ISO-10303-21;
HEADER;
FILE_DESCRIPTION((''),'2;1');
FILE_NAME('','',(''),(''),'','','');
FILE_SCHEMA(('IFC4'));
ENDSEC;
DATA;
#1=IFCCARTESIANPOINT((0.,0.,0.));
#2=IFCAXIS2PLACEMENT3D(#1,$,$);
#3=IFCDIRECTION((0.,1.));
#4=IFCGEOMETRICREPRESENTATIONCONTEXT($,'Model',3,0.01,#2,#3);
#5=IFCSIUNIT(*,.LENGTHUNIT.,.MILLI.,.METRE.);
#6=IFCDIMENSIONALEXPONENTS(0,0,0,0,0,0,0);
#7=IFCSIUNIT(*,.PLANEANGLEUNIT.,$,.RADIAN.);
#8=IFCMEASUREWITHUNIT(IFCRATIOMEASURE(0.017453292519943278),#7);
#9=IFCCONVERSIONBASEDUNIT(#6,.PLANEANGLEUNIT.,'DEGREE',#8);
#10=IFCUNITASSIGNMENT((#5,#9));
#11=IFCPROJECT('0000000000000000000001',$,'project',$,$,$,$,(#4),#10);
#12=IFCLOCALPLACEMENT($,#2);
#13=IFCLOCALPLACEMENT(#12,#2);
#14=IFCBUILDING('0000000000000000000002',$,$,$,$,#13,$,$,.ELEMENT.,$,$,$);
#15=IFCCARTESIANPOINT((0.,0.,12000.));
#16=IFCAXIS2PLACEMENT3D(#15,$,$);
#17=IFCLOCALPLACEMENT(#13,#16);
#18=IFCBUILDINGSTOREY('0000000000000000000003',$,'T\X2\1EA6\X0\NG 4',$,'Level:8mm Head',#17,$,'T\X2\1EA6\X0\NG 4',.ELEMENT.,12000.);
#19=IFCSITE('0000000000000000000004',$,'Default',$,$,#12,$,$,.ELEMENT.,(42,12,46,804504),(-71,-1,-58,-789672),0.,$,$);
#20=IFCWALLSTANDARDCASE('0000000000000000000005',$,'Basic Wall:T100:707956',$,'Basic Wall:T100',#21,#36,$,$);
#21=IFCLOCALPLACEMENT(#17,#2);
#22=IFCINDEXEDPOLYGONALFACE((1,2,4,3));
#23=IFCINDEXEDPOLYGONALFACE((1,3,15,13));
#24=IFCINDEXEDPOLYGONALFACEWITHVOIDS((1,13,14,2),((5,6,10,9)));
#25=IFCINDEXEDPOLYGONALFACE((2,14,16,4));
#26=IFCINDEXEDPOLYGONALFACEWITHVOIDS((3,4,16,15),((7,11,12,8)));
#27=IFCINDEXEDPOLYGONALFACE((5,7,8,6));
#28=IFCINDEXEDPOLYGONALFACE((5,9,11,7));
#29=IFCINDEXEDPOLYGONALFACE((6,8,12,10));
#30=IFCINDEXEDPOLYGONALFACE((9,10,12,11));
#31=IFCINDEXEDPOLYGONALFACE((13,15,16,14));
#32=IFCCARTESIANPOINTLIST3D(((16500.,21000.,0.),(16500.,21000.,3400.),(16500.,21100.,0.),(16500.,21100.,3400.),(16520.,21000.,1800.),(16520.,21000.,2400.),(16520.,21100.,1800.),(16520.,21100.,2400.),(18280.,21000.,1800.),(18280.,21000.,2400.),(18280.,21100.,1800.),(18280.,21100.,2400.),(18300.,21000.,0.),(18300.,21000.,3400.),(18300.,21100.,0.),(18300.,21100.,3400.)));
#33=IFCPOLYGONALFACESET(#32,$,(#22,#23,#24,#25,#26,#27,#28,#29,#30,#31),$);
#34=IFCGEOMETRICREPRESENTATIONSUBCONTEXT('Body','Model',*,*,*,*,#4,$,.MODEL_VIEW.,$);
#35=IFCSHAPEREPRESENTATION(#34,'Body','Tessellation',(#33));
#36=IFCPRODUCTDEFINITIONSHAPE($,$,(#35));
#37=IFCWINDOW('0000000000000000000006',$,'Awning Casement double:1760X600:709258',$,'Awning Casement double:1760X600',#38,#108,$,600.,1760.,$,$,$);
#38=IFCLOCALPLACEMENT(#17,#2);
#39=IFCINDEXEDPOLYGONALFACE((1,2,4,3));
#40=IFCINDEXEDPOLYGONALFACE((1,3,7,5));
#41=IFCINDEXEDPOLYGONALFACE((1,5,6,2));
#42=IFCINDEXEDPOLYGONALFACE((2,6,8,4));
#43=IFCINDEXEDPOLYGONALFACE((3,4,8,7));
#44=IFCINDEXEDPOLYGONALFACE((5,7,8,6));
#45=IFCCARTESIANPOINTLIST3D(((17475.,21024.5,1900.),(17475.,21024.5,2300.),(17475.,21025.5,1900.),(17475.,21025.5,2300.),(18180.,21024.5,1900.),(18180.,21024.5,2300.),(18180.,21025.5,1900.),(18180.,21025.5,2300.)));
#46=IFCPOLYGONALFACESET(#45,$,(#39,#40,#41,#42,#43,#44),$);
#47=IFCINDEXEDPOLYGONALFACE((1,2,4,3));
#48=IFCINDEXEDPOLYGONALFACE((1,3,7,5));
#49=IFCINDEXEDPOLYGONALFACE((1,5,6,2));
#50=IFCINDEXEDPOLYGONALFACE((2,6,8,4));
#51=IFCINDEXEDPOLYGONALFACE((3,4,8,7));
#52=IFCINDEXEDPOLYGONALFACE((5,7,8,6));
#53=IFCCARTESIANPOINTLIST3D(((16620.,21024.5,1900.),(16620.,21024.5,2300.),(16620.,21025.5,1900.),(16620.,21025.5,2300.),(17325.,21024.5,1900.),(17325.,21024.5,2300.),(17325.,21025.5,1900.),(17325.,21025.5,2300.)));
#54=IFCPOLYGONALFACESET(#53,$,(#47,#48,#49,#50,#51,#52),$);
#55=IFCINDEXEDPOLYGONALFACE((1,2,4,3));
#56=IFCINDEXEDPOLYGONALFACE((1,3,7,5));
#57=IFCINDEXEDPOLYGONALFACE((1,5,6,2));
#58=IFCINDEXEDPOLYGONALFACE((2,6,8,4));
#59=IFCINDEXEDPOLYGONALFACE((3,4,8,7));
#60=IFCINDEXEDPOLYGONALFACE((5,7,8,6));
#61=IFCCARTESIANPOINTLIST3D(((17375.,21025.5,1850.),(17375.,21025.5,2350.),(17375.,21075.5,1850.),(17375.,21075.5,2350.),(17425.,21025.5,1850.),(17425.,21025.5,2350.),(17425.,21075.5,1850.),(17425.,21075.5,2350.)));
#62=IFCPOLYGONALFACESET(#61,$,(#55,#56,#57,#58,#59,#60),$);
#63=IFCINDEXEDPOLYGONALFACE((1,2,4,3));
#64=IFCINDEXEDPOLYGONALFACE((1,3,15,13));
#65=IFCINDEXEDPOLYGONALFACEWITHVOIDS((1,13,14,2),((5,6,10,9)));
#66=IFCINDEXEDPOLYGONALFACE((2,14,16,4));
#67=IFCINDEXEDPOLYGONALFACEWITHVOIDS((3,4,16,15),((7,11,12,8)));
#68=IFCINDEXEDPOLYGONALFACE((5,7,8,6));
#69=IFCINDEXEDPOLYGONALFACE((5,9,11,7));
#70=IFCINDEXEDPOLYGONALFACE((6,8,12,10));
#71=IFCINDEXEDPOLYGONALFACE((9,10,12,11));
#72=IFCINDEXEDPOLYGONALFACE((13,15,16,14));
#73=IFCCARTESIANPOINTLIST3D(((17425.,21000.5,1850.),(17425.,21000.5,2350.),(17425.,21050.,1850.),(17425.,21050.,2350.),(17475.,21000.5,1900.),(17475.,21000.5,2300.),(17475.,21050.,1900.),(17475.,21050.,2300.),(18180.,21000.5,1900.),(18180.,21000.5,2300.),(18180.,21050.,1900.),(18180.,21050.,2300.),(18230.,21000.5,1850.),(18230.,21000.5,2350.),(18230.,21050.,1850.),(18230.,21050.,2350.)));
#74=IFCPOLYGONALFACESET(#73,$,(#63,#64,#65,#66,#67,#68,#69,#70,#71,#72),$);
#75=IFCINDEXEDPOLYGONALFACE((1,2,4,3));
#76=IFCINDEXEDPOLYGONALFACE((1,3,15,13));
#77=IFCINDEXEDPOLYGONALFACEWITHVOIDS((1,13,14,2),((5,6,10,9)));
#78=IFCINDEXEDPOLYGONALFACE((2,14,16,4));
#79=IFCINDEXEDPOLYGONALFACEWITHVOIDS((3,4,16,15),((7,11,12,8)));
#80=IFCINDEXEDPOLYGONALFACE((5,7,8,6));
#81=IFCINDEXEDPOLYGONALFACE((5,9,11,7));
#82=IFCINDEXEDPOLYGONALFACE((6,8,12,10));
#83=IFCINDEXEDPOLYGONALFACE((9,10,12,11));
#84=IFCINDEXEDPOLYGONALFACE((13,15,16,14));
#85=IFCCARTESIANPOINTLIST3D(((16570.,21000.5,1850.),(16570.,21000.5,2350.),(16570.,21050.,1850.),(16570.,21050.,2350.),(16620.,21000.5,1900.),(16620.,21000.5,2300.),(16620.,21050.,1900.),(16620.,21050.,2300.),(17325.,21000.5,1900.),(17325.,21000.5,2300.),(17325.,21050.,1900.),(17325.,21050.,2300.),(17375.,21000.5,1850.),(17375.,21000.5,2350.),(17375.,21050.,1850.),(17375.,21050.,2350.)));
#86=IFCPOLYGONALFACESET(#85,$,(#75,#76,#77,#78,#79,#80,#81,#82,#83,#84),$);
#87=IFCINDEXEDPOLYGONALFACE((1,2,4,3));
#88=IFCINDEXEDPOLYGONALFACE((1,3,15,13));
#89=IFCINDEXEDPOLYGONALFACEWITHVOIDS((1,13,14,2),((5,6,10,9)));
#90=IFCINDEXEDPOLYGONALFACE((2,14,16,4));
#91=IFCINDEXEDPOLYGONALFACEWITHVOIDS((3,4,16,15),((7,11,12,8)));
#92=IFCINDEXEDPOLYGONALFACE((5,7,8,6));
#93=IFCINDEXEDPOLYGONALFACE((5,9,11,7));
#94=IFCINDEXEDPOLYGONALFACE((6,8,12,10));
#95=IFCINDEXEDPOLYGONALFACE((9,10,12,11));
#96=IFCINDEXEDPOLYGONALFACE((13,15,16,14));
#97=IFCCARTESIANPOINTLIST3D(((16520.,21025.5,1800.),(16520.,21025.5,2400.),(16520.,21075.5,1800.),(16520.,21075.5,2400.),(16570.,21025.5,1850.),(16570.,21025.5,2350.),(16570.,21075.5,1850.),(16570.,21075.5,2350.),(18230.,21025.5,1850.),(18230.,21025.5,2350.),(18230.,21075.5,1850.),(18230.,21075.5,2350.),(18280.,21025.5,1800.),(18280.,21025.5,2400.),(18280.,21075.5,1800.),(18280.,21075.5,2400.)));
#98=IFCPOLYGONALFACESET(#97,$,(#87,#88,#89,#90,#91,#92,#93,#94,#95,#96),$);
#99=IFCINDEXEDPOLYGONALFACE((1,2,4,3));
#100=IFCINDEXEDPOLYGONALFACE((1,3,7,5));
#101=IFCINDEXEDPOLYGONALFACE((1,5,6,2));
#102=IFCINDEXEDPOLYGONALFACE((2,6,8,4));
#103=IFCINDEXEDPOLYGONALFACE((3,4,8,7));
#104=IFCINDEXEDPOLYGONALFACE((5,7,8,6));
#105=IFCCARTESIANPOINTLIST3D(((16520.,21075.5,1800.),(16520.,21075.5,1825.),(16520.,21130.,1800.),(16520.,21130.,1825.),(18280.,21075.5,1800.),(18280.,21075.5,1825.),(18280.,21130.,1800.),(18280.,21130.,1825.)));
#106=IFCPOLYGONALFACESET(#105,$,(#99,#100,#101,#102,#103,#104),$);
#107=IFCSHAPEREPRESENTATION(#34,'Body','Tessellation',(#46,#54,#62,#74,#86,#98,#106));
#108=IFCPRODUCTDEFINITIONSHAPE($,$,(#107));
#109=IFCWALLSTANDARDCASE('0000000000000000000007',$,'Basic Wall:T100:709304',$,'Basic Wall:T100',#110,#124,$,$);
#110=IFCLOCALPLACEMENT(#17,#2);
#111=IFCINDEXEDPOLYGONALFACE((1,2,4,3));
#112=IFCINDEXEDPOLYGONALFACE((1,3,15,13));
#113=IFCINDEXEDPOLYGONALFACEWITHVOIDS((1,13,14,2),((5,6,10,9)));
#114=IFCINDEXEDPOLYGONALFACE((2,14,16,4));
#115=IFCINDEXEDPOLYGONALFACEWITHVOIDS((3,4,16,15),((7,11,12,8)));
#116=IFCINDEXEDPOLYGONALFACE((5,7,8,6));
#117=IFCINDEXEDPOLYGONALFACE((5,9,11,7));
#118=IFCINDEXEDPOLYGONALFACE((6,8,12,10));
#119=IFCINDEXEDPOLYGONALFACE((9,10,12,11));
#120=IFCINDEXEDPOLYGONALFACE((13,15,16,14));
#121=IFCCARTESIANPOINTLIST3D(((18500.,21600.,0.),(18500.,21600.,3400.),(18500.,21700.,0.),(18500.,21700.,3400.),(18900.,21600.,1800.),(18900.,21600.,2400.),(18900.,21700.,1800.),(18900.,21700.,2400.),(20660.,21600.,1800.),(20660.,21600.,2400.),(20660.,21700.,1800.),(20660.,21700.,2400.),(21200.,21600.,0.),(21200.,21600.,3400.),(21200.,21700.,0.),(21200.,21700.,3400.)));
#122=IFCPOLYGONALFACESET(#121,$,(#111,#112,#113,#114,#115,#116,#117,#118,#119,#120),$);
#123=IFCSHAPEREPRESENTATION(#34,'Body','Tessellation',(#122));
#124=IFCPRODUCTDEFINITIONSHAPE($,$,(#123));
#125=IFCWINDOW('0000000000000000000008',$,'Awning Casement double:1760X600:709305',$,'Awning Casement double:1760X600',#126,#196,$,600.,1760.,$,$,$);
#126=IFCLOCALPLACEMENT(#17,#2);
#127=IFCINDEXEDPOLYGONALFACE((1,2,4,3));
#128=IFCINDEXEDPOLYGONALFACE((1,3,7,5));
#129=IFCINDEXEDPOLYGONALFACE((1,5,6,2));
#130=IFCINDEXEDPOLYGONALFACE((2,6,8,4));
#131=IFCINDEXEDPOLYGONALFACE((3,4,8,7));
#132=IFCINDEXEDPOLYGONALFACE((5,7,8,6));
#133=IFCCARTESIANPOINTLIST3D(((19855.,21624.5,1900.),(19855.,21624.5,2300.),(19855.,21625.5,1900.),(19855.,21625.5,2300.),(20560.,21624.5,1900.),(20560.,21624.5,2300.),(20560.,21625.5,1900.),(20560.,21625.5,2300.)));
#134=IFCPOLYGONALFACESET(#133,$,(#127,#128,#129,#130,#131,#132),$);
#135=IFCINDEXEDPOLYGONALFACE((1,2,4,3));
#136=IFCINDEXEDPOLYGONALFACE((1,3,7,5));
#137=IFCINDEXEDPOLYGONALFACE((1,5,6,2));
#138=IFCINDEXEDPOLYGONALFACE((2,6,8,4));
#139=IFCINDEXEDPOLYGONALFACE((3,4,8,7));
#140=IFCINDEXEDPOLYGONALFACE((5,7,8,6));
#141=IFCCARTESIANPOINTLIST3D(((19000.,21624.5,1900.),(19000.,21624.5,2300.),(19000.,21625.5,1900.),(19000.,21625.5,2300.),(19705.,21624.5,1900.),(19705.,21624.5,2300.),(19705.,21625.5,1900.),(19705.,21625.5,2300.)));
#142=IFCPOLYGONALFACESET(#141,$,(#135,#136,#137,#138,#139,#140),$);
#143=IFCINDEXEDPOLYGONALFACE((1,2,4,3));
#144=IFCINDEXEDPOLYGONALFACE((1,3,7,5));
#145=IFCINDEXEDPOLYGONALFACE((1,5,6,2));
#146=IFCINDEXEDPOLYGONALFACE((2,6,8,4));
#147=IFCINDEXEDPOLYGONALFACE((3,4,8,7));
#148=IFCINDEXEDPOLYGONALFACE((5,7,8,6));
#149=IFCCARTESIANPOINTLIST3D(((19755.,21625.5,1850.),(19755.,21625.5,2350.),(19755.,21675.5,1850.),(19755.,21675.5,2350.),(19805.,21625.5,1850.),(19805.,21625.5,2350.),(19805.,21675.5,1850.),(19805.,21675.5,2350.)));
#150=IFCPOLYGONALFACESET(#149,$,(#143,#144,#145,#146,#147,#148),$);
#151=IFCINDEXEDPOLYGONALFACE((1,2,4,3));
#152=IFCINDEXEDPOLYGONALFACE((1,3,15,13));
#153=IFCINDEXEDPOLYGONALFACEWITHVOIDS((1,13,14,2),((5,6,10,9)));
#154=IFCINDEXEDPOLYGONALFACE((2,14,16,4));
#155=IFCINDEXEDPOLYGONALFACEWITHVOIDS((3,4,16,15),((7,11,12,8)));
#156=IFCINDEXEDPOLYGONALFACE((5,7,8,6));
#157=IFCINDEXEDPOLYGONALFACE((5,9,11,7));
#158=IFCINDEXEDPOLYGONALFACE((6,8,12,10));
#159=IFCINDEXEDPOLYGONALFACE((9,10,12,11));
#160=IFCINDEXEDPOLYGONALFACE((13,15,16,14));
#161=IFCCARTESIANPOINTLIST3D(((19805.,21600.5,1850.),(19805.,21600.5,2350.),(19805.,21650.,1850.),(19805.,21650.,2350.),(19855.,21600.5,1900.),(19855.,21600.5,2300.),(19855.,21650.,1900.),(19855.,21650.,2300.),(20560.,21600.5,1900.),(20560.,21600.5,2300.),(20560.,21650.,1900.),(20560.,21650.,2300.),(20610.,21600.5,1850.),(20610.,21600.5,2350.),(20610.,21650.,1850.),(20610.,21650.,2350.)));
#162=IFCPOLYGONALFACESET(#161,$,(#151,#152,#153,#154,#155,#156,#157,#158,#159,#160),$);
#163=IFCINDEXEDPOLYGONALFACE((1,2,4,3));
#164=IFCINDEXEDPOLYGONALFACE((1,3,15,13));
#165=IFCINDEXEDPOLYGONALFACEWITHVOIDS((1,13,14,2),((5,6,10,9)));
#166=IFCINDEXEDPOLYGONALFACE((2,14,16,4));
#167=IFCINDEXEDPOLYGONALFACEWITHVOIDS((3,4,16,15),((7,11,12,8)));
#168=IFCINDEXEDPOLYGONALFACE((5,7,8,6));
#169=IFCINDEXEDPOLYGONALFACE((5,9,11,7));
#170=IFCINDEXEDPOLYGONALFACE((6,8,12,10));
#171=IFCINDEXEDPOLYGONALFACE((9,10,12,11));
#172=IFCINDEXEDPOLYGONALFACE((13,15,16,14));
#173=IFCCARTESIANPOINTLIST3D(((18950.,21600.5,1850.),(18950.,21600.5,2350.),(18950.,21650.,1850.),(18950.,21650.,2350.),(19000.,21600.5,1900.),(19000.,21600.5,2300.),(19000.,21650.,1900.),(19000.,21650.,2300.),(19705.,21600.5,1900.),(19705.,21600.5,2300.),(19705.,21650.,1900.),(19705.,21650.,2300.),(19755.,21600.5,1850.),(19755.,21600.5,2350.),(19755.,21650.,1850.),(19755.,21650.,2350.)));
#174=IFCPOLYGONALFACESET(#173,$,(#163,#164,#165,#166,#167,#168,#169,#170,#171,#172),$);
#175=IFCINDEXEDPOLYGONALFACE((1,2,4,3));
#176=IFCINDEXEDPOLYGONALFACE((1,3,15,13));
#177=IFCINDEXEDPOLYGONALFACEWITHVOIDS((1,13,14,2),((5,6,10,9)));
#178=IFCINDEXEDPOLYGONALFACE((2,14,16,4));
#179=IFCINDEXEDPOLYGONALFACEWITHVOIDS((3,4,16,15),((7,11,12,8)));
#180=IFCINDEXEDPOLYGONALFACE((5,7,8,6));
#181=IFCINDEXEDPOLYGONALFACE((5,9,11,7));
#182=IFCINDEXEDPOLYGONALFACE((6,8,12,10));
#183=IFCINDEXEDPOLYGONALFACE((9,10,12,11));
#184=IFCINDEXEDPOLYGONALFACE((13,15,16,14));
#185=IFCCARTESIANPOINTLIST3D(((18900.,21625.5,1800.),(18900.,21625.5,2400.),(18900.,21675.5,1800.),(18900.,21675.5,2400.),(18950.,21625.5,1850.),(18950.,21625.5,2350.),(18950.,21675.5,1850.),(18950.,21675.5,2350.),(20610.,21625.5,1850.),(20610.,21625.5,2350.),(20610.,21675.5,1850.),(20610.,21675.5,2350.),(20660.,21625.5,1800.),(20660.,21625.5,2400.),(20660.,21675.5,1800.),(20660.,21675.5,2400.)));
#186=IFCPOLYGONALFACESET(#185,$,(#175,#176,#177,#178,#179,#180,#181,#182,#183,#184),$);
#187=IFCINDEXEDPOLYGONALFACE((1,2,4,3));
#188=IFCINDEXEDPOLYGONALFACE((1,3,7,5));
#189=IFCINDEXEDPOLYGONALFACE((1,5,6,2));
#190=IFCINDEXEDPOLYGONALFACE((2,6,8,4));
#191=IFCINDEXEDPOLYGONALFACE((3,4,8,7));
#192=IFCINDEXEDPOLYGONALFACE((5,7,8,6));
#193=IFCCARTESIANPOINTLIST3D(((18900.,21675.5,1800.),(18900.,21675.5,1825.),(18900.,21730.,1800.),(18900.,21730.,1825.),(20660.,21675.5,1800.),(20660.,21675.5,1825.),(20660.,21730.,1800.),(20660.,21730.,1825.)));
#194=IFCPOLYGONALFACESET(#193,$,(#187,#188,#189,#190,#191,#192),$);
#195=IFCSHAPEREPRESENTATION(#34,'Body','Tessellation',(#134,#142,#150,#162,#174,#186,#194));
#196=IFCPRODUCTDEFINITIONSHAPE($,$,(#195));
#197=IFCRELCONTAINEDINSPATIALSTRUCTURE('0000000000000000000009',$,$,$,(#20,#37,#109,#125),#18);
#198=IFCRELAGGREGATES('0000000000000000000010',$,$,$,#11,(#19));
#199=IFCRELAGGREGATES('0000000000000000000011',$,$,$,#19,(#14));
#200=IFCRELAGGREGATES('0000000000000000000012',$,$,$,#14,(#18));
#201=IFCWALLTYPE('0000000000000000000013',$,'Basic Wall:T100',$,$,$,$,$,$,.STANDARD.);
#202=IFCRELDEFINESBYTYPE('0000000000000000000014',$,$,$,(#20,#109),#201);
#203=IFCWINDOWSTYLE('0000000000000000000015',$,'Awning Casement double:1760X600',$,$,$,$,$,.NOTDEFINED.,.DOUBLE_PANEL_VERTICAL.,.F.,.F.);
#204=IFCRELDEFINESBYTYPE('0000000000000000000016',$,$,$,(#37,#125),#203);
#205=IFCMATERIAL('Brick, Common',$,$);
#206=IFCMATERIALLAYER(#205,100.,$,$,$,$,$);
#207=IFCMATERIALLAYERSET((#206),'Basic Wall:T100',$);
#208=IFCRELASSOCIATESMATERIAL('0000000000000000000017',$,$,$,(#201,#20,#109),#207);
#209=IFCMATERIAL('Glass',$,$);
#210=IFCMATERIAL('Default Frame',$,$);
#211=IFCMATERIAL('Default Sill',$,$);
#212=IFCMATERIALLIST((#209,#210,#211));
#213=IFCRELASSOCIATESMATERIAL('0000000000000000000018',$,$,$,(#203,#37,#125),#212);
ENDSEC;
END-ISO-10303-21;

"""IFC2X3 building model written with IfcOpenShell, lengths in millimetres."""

from ifc_helpers import new_model, entity, si_unit, converted_unit, direction, frame, frame_2d, origin, origin_2d_with_axis, place, context, subcontext, project, spatial, polyline, rectangle, outline, extrude, source, transform, mapped, material, material_list, layer, layer_set, layer_usage, type_object, type_shapes, element, fill, save


model = new_model("IFC2X3")

# Units and contexts
model_context = context("Model", 3, precision=0.01, world=origin(), true_north=direction((0.0, 1.0)))
body_context = subcontext(model_context, "Body", "Model", "MODEL_VIEW")
ifc_project = project(units=[si_unit("LENGTHUNIT", "METRE", prefix="MILLI"), converted_unit("PLANEANGLEUNIT", "DEGREE", entity("IfcRatioMeasure", 0.017453292519943278), si_unit("PLANEANGLEUNIT", "RADIAN"), dimensions=[0, 0, 0, 0, 0, 0, 0])], contexts=[model_context])

# Site, building, storey
site_placement = place(None, origin())
site = spatial("IfcSite", under=ifc_project, at=site_placement, Name="Default", CompositionType="ELEMENT", RefLatitude=(42, 12, 46, 804504), RefLongitude=(-71, -1, -58, -789672), RefElevation=0.0)
building_placement = place(site_placement, origin())
building = spatial("IfcBuilding", under=site, at=building_placement, CompositionType="ELEMENT")
storey_placement = place(building_placement, frame((0.0, 0.0, 12000.0)))
storey = spatial("IfcBuildingStorey", under=building, at=storey_placement, Name="TẦNG 4", ObjectType="Level:8mm Head", LongName="TẦNG 4", CompositionType="ELEMENT", Elevation=12000.0)

# Shared definitions
ifc_material_1 = material(Name="Glass")

# Shared definitions
ifc_material_2 = material(Name="Brick, Common")
ifc_layer_1 = layer(ifc_material_2, 100.0)
ifc_layer_set_1 = layer_set([ifc_layer_1], Name="Basic Wall:T100")
wall_type_1 = type_object("IfcWallType", Name="Basic Wall:T100", PredefinedType="STANDARD", material=ifc_layer_set_1)

# Walls, openings, windows
ifc_layer_usage_1 = layer_usage(ifc_layer_set_1, "AXIS2", "NEGATIVE", 50.0)
wall_1_placement = place(storey_placement, frame((16500.0, 21050.0, 0.0)))
wall_1 = element("IfcWallStandardCase", 1, at=wall_1_placement, inside=storey, type_object=wall_type_1, material=ifc_layer_usage_1, Name="Basic Wall:T100:707956", ObjectType="Basic Wall:T100", context=body_context, shape_type="SweptSolid", body=[
    extrude(rectangle(XDim=1800.0, YDim=100.0, at=frame_2d((900.0, 0.0), x_axis=(-1.0, 0.0))), origin(), (0.0, 0.0, 1.0), 3400.0),
])
opening_1_placement = place(wall_1_placement, frame((20.0, -50.0, 1800.0)))
opening_1 = element("IfcOpeningElement", 2, at=opening_1_placement, cuts=wall_1, ObjectType="Opening", context=body_context, shape_type="SweptSolid", body=[
    extrude(rectangle(XDim=600.0, YDim=1760.0, at=frame_2d((300.0, 880.0), x_axis=(1.0, 0.0))), frame((0.0, 0.0, 0.0), z_axis=(0.0, 1.0, 0.0), x_axis=(0.0, 0.0, 1.0)), (0.0, 0.0, 1.0), 100.0),
])
ifc_material_3 = material(Name="Default Frame")
ifc_material_4 = material(Name="Default Sill")
ifc_material_list = material_list([ifc_material_1, ifc_material_3, ifc_material_4])
window_style = type_object("IfcWindowStyle", Name="Awning Casement double:1760X600", ConstructionType="NOTDEFINED", OperationType="DOUBLE_PANEL_VERTICAL", ParameterTakesPrecedence=False, Sizeable=False, material=ifc_material_list)
shared_shape_1 = source(origin(), body_context, "Body", "SweptSolid", [
    extrude(rectangle(XDim=1.0, YDim=705.0, at=origin_2d_with_axis()), frame((1307.5, 25.0, 100.0), z_axis=(0.0, 0.0, 1.0), x_axis=(0.0, 1.0, 0.0)), (0.0, 0.0, 1.0), 400.0),
    extrude(rectangle(XDim=1.0, YDim=705.0, at=origin_2d_with_axis()), frame((452.5, 25.0, 100.0), z_axis=(0.0, 0.0, 1.0), x_axis=(0.0, 1.0, 0.0)), (0.0, 0.0, 1.0), 400.0),
    extrude(rectangle(XDim=50.0, YDim=50.0, at=origin_2d_with_axis()), frame((880.0, 50.5, 50.0), z_axis=(0.0, 0.0, 1.0), x_axis=(0.0, 1.0, 0.0)), (0.0, 0.0, 1.0), 500.0),
    extrude(outline(polyline([(-250.0, -402.5), (250.0, -402.5), (250.0, 402.5), (-250.0, 402.5), (-250.0, -402.5)]), holes=[polyline([(-200.0, -352.5), (-200.0, 352.5), (200.0, 352.5), (200.0, -352.5), (-200.0, -352.5)])]), frame((1307.5, 0.5, 300.0), z_axis=(0.0, 1.0, 0.0), x_axis=(0.0, 0.0, -1.0)), (0.0, 0.0, 1.0), 49.5),
    extrude(outline(polyline([(-250.0, -402.5), (250.0, -402.5), (250.0, 402.5), (-250.0, 402.5), (-250.0, -402.5)]), holes=[polyline([(-200.0, -352.5), (-200.0, 352.5), (200.0, 352.5), (200.0, -352.5), (-200.0, -352.5)])]), frame((452.5, 0.5, 300.0), z_axis=(0.0, 1.0, 0.0), x_axis=(0.0, 0.0, -1.0)), (0.0, 0.0, 1.0), 49.5),
    extrude(outline(polyline([(-300.0, -880.0), (300.0, -880.0), (300.0, 880.0), (-300.0, 880.0), (-300.0, -880.0)]), holes=[polyline([(-250.0, -830.0), (-250.0, 830.0), (250.0, 830.0), (250.0, -830.0), (-250.0, -830.0)])]), frame((880.0, 25.5, 300.0), z_axis=(0.0, 1.0, 0.0), x_axis=(0.0, 0.0, -1.0)), (0.0, 0.0, 1.0), 50.0),
    extrude(rectangle(XDim=54.5, YDim=1760.0, at=origin_2d_with_axis()), frame((880.0, 102.8, 0.0), z_axis=(0.0, 0.0, 1.0), x_axis=(0.0, 1.0, 0.0)), (0.0, 0.0, 1.0), 25.0),
])
type_shapes(window_style, [shared_shape_1])
window_1_placement = place(opening_1_placement, origin())
window_1 = element("IfcWindow", 3, at=window_1_placement, inside=storey, type_object=window_style, material=ifc_material_list, Name="Awning Casement double:1760X600:709258", ObjectType="Awning Casement double:1760X600", OverallHeight=600.0, OverallWidth=1760.0, context=body_context, shape_type="MappedRepresentation", body=[
    mapped(shared_shape_1, transform((0.0, 0.0, 0.0), scale=1.0)),
])
fill(opening_1, window_1)
wall_2_placement = place(storey_placement, frame((18500.0, 21650.0, 0.0)))
wall_2 = element("IfcWallStandardCase", 4, at=wall_2_placement, inside=storey, type_object=wall_type_1, material=ifc_layer_usage_1, Name="Basic Wall:T100:709304", ObjectType="Basic Wall:T100", context=body_context, shape_type="SweptSolid", body=[
    extrude(rectangle(XDim=2700.0, YDim=100.0, at=frame_2d((1350.0, 0.0), x_axis=(-1.0, 0.0))), origin(), (0.0, 0.0, 1.0), 3400.0),
])
opening_2_placement = place(wall_2_placement, frame((400.0, -50.0, 1800.0)))
opening_2 = element("IfcOpeningElement", 5, at=opening_2_placement, cuts=wall_2, ObjectType="Opening", context=body_context, shape_type="SweptSolid", body=[
    extrude(rectangle(XDim=600.0, YDim=1760.0, at=frame_2d((300.0, 880.0), x_axis=(1.0, 0.0))), frame((0.0, 0.0, 0.0), z_axis=(0.0, 1.0, 0.0), x_axis=(0.0, 0.0, 1.0)), (0.0, 0.0, 1.0), 100.0),
])
window_2_placement = place(opening_2_placement, origin())
window_2 = element("IfcWindow", 6, at=window_2_placement, inside=storey, type_object=window_style, material=ifc_material_list, Name="Awning Casement double:1760X600:709305", ObjectType="Awning Casement double:1760X600", OverallHeight=600.0, OverallWidth=1760.0, context=body_context, shape_type="MappedRepresentation", body=[
    mapped(shared_shape_1, transform((0.0, 0.0, 0.0), scale=1.0)),
])
fill(opening_2, window_2)

save(model, "model.ifc")
